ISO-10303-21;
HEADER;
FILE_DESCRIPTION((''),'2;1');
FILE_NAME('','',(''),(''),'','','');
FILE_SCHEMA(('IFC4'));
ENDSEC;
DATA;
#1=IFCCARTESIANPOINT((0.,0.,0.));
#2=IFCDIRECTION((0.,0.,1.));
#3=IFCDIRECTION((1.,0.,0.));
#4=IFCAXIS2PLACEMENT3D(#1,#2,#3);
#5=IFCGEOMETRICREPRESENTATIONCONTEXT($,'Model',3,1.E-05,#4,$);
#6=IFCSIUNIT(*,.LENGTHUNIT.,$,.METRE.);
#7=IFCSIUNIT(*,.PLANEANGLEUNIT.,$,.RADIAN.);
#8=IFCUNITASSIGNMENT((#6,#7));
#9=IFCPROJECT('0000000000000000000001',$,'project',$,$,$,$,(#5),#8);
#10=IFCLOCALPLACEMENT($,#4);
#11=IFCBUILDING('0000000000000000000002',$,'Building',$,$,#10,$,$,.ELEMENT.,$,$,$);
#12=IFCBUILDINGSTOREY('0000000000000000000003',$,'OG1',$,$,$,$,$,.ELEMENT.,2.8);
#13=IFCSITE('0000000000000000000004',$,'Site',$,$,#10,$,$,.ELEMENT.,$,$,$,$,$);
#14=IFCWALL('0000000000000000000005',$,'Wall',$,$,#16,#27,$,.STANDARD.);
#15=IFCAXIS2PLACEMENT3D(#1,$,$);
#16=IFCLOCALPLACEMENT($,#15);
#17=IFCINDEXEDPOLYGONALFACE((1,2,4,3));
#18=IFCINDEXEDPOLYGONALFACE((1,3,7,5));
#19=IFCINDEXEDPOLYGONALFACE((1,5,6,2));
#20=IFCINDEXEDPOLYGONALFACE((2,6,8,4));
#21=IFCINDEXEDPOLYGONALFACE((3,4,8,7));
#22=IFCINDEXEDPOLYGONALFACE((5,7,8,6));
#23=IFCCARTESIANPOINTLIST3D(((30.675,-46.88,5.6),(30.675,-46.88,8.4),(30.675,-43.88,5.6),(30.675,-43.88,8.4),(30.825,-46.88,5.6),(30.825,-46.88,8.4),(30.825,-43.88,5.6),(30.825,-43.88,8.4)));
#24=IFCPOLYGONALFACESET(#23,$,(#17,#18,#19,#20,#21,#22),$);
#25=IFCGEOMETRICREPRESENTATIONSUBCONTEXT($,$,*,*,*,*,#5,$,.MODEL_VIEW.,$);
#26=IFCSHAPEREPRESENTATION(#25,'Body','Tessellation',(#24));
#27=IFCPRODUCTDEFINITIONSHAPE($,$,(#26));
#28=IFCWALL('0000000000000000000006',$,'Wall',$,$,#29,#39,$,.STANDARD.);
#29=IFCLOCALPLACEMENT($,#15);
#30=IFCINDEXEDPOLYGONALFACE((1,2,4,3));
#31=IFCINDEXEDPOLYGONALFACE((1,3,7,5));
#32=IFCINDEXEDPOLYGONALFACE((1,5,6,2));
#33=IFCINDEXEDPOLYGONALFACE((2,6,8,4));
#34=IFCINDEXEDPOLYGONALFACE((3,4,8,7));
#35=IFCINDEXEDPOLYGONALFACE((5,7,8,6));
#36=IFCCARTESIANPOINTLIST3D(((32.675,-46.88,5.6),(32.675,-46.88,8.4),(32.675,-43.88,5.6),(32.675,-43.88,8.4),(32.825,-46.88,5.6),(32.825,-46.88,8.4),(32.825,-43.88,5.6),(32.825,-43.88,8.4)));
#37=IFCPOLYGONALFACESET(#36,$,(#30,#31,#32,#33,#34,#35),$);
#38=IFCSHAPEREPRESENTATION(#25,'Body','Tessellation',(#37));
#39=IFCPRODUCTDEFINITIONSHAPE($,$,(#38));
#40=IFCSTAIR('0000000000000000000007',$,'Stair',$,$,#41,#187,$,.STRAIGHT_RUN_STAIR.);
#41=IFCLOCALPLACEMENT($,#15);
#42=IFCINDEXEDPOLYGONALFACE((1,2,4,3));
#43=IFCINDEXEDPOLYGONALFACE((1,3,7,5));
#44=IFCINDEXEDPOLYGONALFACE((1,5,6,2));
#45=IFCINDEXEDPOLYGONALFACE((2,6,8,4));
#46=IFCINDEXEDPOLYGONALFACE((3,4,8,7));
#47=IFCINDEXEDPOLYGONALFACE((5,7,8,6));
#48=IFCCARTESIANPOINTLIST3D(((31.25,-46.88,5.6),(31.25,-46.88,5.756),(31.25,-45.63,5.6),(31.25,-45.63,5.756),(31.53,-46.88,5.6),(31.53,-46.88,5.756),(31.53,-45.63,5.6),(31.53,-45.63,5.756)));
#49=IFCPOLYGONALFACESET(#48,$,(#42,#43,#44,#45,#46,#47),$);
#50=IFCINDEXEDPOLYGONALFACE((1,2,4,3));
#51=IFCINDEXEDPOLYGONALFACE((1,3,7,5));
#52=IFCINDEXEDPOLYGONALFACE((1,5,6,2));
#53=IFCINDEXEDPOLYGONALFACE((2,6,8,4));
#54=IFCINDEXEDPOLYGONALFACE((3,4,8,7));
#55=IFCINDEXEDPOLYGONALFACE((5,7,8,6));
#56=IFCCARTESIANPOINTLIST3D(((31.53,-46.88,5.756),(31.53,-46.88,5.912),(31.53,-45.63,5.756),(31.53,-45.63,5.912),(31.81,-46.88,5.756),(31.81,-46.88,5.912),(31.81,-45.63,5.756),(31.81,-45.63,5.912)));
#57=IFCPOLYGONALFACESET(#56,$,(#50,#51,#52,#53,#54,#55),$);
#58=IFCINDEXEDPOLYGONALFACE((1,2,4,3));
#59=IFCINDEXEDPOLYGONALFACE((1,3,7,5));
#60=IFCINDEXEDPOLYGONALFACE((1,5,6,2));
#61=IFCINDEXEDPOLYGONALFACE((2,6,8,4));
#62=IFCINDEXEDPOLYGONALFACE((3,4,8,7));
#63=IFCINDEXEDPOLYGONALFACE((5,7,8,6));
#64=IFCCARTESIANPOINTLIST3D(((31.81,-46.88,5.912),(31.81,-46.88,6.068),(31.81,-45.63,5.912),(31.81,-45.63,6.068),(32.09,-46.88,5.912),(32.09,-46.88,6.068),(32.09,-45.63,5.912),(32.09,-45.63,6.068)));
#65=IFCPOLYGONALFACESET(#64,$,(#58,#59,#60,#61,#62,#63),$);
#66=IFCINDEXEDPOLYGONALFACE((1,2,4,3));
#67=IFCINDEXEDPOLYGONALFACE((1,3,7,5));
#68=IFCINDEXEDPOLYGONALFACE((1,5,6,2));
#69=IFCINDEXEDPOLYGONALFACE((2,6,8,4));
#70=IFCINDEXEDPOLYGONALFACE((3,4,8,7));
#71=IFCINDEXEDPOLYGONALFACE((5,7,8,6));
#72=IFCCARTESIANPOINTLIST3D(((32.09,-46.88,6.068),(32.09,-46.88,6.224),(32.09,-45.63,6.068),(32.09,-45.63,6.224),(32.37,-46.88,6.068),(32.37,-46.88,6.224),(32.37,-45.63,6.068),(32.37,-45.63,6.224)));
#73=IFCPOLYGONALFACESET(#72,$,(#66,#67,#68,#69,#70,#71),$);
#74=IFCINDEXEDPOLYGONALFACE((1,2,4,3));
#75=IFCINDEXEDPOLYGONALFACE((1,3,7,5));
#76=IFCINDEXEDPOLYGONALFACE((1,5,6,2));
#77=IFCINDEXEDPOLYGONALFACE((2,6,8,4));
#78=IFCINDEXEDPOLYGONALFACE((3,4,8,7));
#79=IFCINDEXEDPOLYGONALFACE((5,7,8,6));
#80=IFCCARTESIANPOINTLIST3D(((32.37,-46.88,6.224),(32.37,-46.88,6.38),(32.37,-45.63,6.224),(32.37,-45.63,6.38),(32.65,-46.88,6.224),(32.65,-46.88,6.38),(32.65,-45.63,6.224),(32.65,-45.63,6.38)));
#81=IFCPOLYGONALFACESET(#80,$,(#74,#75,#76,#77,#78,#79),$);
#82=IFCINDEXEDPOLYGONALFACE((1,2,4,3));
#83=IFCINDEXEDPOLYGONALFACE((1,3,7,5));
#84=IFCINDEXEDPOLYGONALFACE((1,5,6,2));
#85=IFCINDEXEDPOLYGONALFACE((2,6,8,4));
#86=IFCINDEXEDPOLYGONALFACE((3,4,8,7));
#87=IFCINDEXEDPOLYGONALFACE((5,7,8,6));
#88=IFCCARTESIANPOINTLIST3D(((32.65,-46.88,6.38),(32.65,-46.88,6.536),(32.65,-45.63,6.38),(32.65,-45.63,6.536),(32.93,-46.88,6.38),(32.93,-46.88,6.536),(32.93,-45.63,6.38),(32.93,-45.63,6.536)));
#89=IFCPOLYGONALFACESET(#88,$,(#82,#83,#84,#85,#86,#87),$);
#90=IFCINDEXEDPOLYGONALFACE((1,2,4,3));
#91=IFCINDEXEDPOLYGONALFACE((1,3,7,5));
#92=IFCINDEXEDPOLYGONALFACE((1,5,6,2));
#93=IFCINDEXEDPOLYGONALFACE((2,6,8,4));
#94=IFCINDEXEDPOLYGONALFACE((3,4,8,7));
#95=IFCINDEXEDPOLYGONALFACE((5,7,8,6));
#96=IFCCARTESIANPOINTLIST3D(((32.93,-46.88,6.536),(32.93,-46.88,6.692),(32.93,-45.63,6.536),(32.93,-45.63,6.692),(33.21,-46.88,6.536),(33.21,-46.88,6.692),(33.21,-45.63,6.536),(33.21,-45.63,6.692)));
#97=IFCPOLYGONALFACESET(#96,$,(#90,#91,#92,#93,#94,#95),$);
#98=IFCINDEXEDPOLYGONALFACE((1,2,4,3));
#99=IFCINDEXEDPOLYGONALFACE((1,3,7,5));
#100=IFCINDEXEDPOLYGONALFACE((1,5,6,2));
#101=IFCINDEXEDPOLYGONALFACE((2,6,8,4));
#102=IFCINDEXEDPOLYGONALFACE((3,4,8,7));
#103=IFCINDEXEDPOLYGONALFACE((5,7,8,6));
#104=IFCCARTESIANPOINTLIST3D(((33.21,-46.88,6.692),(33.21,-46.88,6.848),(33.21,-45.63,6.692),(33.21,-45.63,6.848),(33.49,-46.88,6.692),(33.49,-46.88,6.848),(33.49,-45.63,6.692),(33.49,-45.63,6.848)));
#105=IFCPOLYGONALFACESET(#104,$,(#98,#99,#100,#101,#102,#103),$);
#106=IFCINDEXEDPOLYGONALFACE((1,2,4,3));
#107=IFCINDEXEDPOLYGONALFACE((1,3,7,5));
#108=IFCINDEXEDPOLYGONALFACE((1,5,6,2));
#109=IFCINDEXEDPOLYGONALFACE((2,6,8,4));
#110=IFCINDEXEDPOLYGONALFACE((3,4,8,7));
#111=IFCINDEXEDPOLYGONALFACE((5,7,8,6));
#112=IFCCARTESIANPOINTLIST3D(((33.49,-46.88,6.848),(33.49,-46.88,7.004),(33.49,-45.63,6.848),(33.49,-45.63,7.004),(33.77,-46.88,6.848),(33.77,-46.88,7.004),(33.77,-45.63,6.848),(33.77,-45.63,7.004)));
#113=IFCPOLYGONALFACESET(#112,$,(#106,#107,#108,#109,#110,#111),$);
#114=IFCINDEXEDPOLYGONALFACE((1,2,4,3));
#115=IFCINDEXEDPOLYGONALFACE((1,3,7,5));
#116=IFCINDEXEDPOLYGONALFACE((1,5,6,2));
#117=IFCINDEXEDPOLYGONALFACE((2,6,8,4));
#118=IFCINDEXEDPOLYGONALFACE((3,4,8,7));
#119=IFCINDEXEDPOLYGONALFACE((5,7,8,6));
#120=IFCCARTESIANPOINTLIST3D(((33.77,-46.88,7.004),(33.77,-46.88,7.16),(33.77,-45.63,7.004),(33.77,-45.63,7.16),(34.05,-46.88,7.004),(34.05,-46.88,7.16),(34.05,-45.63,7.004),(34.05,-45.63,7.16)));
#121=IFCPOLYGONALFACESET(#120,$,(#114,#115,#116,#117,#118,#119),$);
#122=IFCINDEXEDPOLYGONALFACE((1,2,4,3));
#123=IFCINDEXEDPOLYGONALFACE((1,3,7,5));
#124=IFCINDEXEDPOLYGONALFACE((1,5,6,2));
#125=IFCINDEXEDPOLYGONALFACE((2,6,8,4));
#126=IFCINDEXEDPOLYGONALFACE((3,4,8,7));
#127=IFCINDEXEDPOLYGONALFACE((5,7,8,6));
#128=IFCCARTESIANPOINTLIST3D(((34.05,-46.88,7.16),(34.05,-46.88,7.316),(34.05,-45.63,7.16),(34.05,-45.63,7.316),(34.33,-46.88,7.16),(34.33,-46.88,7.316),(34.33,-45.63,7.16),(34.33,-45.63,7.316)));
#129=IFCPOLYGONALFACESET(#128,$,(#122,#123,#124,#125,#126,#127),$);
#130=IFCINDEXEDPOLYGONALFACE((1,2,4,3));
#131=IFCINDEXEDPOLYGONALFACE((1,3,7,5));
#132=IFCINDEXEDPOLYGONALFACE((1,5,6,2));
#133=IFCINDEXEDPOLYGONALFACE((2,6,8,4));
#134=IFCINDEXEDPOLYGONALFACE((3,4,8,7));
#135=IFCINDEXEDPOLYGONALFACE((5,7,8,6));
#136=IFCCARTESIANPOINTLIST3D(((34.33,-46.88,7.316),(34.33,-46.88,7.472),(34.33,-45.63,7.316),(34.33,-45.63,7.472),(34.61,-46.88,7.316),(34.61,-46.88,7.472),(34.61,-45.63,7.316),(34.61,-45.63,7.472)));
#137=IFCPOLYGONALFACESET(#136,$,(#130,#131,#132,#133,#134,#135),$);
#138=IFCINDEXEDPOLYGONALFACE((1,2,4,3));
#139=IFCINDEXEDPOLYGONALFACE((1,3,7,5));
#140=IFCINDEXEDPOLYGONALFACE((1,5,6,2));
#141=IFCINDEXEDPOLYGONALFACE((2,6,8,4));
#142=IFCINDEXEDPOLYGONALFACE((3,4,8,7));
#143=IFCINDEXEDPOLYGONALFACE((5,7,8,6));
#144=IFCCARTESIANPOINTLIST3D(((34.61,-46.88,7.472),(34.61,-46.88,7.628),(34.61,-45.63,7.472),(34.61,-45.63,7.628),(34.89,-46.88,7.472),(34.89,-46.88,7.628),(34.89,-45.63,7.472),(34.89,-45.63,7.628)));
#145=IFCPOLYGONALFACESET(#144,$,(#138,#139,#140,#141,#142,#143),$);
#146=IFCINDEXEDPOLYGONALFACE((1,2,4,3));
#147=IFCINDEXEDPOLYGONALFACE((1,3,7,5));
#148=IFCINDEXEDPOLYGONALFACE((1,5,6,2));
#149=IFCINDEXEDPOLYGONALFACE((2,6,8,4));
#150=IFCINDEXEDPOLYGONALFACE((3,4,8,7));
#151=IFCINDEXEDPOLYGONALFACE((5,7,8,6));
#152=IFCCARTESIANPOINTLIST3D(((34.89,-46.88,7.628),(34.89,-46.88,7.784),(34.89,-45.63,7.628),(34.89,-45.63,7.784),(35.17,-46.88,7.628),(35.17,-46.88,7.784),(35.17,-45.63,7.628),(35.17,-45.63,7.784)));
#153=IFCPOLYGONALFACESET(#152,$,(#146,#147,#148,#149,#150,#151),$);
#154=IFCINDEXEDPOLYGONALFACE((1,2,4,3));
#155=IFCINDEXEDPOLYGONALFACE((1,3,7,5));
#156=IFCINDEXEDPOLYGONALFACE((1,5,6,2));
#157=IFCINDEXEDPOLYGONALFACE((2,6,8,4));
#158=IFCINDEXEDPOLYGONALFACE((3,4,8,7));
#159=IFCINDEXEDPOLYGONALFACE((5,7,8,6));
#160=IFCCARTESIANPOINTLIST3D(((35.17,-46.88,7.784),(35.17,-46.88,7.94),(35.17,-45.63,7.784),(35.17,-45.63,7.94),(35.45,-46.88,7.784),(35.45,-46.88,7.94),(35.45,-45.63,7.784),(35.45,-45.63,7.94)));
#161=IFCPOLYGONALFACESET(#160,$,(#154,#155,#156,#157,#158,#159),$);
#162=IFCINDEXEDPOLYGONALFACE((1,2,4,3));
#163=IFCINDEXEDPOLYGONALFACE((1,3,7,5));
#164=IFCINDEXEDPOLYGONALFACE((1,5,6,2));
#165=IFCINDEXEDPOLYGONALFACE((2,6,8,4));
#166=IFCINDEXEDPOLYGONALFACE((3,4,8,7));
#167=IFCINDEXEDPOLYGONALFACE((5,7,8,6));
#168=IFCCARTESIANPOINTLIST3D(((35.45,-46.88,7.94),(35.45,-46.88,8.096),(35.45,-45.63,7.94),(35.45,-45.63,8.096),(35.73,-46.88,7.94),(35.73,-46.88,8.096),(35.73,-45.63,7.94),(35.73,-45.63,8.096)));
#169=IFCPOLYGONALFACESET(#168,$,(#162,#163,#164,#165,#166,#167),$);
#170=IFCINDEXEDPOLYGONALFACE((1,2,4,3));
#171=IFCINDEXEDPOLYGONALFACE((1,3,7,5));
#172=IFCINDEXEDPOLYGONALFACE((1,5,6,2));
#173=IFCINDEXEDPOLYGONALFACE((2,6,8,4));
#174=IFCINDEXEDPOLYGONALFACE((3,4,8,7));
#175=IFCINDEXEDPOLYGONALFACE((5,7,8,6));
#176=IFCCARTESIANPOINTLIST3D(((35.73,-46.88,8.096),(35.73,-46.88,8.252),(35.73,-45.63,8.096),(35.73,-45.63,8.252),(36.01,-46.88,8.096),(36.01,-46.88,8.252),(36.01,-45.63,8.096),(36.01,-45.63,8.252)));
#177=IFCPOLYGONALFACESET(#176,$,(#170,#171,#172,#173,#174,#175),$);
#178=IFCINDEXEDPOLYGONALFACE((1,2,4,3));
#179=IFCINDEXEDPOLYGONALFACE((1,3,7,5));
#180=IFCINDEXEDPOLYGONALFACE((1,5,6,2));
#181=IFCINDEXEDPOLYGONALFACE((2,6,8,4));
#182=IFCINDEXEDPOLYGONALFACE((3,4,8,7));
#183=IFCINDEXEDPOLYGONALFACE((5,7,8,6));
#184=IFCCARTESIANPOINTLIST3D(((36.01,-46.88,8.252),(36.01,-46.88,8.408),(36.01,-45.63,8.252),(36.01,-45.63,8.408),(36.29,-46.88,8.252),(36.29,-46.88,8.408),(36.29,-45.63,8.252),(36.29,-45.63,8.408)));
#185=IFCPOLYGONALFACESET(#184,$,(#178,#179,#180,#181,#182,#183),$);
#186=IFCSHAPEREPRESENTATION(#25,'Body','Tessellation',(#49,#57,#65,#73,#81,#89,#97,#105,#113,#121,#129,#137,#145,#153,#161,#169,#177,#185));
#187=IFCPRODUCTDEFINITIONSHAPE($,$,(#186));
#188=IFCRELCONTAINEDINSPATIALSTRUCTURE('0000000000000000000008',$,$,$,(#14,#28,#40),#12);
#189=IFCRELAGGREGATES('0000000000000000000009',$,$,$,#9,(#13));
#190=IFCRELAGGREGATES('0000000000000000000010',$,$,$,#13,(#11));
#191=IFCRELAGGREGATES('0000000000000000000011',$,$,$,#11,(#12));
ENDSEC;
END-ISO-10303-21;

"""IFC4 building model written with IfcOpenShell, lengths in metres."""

from ifc_helpers import new_model, si_unit, frame, frame_2d, origin, origin_with_axes, place, context, subcontext, project, spatial, rectangle, extrude, element, save


model = new_model("IFC4")

# Units and contexts
model_context = context("Model", 3, precision=1e-05, world=origin_with_axes())
sub_context = subcontext(model_context, None, None, "MODEL_VIEW")
ifc_project = project(units=[si_unit("LENGTHUNIT", "METRE"), si_unit("PLANEANGLEUNIT", "RADIAN")], contexts=[model_context])

# Site, building, storey
placement_1 = place(None, origin_with_axes())
site = spatial("IfcSite", under=ifc_project, at=placement_1, Name="Site", CompositionType="ELEMENT")
building = spatial("IfcBuilding", under=site, at=placement_1, Name="Building", CompositionType="ELEMENT")
storey = spatial("IfcBuildingStorey", under=building, Name="OG1", CompositionType="ELEMENT", Elevation=2.8)

# Shared definitions
placement_2 = place(placement_1, frame((0.0, 0.0, 2.8)))

# Walls
for number, where, x_axis, name in (
    (1, (30.75, -46.88, 2.8), (0.0, 1.0, 0.0), "Wall"),
    (2, (32.75, -46.88, 2.8), (0.0, 1.0, 0.0), "Wall"),
):
    element("IfcWall", number, at=place(placement_2, frame(where, x_axis=x_axis)), inside=storey, Name=name, PredefinedType="STANDARD", context=sub_context, shape_type="SweptSolid", body=[
        extrude(rectangle(XDim=3.0, YDim=0.15, at=frame_2d((1.5, 0.0))), origin(), (0.0, 0.0, 1.0), 2.8),
    ])

# Stair
stair_placement = place(placement_2, frame((31.25, -46.88, 2.8)))
element("IfcStair", 3, at=stair_placement, inside=storey, Name="Stair", PredefinedType="STRAIGHT_RUN_STAIR", context=sub_context, shape_type="SolidModel", body=[
    extrude(rectangle(XDim=0.28, YDim=1.25, at=frame_2d((0.14, 0.625))), origin(), (0.0, 0.0, 1.0), 0.156),
    extrude(rectangle(XDim=0.28, YDim=1.25, at=frame_2d((0.14, 0.625))), frame((0.28, 0.0, 0.156)), (0.0, 0.0, 1.0), 0.156),
    extrude(rectangle(XDim=0.28, YDim=1.25, at=frame_2d((0.14, 0.625))), frame((0.56, 0.0, 0.312)), (0.0, 0.0, 1.0), 0.156),
    extrude(rectangle(XDim=0.28, YDim=1.25, at=frame_2d((0.14, 0.625))), frame((0.84, 0.0, 0.468)), (0.0, 0.0, 1.0), 0.156),
    extrude(rectangle(XDim=0.28, YDim=1.25, at=frame_2d((0.14, 0.625))), frame((1.12, 0.0, 0.624)), (0.0, 0.0, 1.0), 0.156),
    extrude(rectangle(XDim=0.28, YDim=1.25, at=frame_2d((0.14, 0.625))), frame((1.4, 0.0, 0.78)), (0.0, 0.0, 1.0), 0.156),
    extrude(rectangle(XDim=0.28, YDim=1.25, at=frame_2d((0.14, 0.625))), frame((1.68, 0.0, 0.936)), (0.0, 0.0, 1.0), 0.156),
    extrude(rectangle(XDim=0.28, YDim=1.25, at=frame_2d((0.14, 0.625))), frame((1.96, 0.0, 1.092)), (0.0, 0.0, 1.0), 0.156),
    extrude(rectangle(XDim=0.28, YDim=1.25, at=frame_2d((0.14, 0.625))), frame((2.24, 0.0, 1.248)), (0.0, 0.0, 1.0), 0.156),
    extrude(rectangle(XDim=0.28, YDim=1.25, at=frame_2d((0.14, 0.625))), frame((2.52, 0.0, 1.404)), (0.0, 0.0, 1.0), 0.156),
    extrude(rectangle(XDim=0.28, YDim=1.25, at=frame_2d((0.14, 0.625))), frame((2.8, 0.0, 1.56)), (0.0, 0.0, 1.0), 0.156),
    extrude(rectangle(XDim=0.28, YDim=1.25, at=frame_2d((0.14, 0.625))), frame((3.08, 0.0, 1.716)), (0.0, 0.0, 1.0), 0.156),
    extrude(rectangle(XDim=0.28, YDim=1.25, at=frame_2d((0.14, 0.625))), frame((3.36, 0.0, 1.872)), (0.0, 0.0, 1.0), 0.156),
    extrude(rectangle(XDim=0.28, YDim=1.25, at=frame_2d((0.14, 0.625))), frame((3.64, 0.0, 2.028)), (0.0, 0.0, 1.0), 0.156),
    extrude(rectangle(XDim=0.28, YDim=1.25, at=frame_2d((0.14, 0.625))), frame((3.92, 0.0, 2.184)), (0.0, 0.0, 1.0), 0.156),
    extrude(rectangle(XDim=0.28, YDim=1.25, at=frame_2d((0.14, 0.625))), frame((4.2, 0.0, 2.34)), (0.0, 0.0, 1.0), 0.156),
    extrude(rectangle(XDim=0.28, YDim=1.25, at=frame_2d((0.14, 0.625))), frame((4.48, 0.0, 2.496)), (0.0, 0.0, 1.0), 0.156),
    extrude(rectangle(XDim=0.28, YDim=1.25, at=frame_2d((0.14, 0.625))), frame((4.76, 0.0, 2.652)), (0.0, 0.0, 1.0), 0.156),
])

save(model, "model.ifc")
